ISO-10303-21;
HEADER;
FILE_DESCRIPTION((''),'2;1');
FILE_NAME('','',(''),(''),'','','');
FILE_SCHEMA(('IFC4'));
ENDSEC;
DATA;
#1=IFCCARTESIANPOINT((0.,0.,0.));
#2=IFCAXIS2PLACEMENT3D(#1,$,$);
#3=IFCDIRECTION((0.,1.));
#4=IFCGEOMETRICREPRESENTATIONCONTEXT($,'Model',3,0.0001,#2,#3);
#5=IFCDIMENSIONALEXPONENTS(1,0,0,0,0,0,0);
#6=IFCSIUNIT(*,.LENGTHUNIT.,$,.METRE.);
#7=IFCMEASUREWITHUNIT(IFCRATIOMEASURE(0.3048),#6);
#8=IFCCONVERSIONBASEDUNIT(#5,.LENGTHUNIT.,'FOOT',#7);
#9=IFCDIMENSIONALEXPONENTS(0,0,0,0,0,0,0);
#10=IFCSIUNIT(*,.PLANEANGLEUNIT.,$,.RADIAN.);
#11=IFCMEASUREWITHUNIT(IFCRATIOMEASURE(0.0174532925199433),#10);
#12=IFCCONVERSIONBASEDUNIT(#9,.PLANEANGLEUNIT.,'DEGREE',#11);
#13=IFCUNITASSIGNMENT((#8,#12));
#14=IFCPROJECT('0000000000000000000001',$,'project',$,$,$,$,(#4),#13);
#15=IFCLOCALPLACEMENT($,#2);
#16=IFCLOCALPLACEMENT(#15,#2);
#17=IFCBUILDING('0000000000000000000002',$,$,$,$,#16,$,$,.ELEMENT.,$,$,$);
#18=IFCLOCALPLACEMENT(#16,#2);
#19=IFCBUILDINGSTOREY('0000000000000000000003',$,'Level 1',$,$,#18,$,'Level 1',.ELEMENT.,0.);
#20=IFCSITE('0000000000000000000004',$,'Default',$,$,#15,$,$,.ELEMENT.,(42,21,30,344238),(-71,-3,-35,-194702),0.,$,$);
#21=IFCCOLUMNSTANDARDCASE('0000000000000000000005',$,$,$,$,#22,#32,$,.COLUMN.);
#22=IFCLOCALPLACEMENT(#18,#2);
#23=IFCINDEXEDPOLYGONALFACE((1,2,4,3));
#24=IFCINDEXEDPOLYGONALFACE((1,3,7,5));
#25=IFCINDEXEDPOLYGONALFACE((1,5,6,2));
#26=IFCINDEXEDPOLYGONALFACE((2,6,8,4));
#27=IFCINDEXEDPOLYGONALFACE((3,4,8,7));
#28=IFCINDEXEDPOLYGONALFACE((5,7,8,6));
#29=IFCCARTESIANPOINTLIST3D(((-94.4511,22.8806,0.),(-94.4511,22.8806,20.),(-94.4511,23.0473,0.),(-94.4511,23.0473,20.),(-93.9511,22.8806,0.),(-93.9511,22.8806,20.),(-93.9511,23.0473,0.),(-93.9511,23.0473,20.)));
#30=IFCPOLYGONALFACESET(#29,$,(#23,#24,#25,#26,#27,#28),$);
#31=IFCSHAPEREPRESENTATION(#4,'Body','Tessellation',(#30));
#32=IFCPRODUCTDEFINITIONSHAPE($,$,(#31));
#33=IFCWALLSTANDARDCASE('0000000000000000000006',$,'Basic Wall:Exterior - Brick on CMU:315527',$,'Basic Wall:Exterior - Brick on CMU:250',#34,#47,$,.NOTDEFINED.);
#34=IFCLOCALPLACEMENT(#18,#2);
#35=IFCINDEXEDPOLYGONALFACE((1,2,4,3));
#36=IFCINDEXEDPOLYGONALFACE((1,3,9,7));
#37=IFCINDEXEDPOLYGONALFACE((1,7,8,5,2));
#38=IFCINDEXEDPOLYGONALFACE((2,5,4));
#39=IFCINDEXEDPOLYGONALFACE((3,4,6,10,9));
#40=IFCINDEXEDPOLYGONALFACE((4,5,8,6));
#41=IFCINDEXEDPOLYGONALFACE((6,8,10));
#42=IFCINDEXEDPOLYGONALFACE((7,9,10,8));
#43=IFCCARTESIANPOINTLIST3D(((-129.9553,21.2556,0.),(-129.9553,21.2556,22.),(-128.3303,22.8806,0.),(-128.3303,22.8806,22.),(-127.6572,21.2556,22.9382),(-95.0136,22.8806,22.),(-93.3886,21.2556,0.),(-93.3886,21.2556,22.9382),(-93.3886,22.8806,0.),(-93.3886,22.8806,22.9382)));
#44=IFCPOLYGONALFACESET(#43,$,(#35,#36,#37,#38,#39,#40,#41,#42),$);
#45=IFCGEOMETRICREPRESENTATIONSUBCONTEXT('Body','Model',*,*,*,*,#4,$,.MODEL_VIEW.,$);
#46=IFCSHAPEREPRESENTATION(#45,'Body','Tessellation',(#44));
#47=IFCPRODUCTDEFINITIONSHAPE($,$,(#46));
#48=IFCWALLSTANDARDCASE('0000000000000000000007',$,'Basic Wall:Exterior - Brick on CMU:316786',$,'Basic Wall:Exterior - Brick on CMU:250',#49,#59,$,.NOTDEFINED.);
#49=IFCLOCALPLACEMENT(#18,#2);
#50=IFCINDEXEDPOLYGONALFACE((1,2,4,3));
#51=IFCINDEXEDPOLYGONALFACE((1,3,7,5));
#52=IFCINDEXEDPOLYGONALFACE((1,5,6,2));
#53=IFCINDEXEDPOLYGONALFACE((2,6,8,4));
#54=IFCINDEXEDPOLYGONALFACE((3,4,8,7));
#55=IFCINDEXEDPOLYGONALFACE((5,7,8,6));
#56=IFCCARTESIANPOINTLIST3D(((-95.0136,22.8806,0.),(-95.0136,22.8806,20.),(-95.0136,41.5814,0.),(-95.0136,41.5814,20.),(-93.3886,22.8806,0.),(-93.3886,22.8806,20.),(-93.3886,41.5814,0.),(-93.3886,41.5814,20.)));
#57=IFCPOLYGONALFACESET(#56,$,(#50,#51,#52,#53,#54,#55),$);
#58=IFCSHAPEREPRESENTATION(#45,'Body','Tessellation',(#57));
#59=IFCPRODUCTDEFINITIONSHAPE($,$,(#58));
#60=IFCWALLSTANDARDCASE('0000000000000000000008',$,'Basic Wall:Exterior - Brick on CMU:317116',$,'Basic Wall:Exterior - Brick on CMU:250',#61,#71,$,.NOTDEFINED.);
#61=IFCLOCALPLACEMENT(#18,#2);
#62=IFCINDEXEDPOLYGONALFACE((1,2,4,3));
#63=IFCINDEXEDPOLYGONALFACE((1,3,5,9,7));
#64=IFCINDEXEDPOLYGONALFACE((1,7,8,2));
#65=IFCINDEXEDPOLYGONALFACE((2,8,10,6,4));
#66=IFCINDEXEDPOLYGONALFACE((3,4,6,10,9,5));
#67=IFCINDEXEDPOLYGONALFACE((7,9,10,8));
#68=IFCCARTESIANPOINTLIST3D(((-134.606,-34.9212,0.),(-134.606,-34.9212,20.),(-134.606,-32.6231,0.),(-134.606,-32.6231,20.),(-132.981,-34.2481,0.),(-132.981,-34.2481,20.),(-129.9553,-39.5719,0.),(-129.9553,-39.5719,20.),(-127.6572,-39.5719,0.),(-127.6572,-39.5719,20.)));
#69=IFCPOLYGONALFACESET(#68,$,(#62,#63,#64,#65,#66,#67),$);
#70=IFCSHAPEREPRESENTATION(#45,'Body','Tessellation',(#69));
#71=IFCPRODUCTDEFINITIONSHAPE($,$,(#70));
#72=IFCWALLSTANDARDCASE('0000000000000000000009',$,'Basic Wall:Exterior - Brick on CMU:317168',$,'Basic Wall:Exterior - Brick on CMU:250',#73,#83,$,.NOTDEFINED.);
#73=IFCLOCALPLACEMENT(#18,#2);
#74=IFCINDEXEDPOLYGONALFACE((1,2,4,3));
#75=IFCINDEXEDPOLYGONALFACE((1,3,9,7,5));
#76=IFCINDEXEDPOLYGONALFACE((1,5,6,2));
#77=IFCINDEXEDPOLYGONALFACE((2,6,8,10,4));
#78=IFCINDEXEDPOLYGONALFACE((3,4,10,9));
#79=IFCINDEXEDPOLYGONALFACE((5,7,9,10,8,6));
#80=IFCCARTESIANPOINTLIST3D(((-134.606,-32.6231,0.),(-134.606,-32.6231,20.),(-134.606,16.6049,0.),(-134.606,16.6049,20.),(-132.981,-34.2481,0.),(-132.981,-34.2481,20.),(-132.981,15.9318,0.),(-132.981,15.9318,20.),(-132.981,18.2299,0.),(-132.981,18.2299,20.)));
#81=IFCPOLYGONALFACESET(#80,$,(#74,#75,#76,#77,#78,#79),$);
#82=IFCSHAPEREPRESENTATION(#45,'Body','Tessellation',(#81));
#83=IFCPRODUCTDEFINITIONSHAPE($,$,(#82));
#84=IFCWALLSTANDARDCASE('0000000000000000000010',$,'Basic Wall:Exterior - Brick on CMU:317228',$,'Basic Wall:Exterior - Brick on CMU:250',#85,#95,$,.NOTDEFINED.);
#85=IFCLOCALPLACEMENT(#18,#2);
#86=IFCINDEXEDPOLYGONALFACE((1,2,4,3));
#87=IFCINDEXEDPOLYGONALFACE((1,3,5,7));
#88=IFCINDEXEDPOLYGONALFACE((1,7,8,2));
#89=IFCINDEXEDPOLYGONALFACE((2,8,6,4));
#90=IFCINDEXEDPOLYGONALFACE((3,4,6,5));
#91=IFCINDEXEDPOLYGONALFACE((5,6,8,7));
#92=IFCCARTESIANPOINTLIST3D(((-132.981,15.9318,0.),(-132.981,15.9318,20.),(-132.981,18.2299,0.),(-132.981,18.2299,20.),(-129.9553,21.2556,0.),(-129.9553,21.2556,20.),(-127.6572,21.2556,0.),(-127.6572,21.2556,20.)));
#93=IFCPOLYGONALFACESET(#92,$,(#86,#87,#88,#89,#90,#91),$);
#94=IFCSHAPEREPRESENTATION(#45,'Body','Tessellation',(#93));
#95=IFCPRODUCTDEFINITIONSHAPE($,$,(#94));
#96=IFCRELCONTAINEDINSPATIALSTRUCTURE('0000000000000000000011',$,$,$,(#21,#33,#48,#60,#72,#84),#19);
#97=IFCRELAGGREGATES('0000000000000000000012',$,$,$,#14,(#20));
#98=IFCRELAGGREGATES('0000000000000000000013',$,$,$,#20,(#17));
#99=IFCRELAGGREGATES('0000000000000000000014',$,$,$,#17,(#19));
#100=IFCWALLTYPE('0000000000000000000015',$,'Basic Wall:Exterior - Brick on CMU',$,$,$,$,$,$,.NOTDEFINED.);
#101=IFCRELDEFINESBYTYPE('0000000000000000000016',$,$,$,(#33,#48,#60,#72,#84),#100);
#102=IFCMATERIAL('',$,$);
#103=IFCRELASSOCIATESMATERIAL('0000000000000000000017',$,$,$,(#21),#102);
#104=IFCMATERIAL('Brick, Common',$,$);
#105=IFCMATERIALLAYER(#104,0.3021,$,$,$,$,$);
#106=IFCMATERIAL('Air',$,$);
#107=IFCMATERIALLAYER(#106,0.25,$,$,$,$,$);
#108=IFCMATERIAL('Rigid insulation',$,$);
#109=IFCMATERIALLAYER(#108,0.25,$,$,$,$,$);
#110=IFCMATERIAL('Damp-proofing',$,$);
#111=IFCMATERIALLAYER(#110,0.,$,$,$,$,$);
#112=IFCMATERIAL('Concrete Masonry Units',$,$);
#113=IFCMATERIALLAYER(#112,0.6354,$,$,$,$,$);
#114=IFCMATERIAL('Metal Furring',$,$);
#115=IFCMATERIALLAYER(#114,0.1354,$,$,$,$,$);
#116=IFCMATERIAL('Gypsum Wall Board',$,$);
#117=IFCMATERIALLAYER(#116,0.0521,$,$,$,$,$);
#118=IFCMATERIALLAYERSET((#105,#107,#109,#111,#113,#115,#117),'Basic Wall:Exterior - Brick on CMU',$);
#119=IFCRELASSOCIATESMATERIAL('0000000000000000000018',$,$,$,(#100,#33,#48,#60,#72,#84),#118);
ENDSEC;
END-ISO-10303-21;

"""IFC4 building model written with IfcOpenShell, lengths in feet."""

from ifc_helpers import new_model, entity, si_unit, converted_unit, direction, frame, frame_2d, origin, place, context, subcontext, project, spatial, polyline, rectangle, outline, extrude, clip, bounded_halfspace, material, layer, layer_set, layer_usage, type_object, element, save


model = new_model("IFC4")

# Units and contexts
model_context = context("Model", 3, precision=0.0001, world=origin(), true_north=direction((0.0, 1.0)))
body_context = subcontext(model_context, "Body", "Model", "MODEL_VIEW")
ifc_project = project(units=[converted_unit("LENGTHUNIT", "FOOT", entity("IfcRatioMeasure", 0.3048), si_unit("LENGTHUNIT", "METRE"), dimensions=[1, 0, 0, 0, 0, 0, 0]), converted_unit("PLANEANGLEUNIT", "DEGREE", entity("IfcRatioMeasure", 0.0174532925199433), si_unit("PLANEANGLEUNIT", "RADIAN"), dimensions=[0, 0, 0, 0, 0, 0, 0])], contexts=[model_context])

# Site, building, storey
site_placement = place(None, origin())
site = spatial("IfcSite", under=ifc_project, at=site_placement, Name="Default", CompositionType="ELEMENT", RefLatitude=(42, 21, 30, 344238), RefLongitude=(-71, -3, -35, -194702), RefElevation=0.0)
building_placement = place(site_placement, origin())
building = spatial("IfcBuilding", under=site, at=building_placement, CompositionType="ELEMENT")
storey_placement = place(building_placement, origin())
storey = spatial("IfcBuildingStorey", under=building, at=storey_placement, Name="Level 1", LongName="Level 1", CompositionType="ELEMENT", Elevation=0.0)

# Column
ifc_material_1 = material(Name="")
wall_1_placement = place(storey_placement, frame((-94.2011, 22.8806, 0.0), z_axis=(0.0, 0.0, 1.0), x_axis=(0.0, 1.0, 0.0)))
for number, where, z_axis, x_axis in (
    (1, (0.0833, 0.0, 0.0), (0.0, 0.0, 1.0), (1.0, 0.0, 0.0)),
):
    element("IfcColumnStandardCase", number, at=place(wall_1_placement, frame(where, z_axis=z_axis, x_axis=x_axis)), inside=storey, material=ifc_material_1, PredefinedType="COLUMN", context=model_context, shape_type="SweptSolid", body=[
        extrude(rectangle(XDim=0.1667, YDim=0.5), origin(), (0.0, 0.0, 1.0), 20.0),
    ])

# Walls
ifc_material_2 = material(Name="Brick, Common")
ifc_layer_1 = layer(ifc_material_2, 0.3021)
ifc_material_3 = material(Name="Air")
ifc_layer_2 = layer(ifc_material_3, 0.25)
ifc_material_4 = material(Name="Rigid insulation")
ifc_layer_3 = layer(ifc_material_4, 0.25)
ifc_material_5 = material(Name="Damp-proofing")
ifc_layer_4 = layer(ifc_material_5, 0.0)
ifc_material_6 = material(Name="Concrete Masonry Units")
ifc_layer_5 = layer(ifc_material_6, 0.6354)
ifc_material_7 = material(Name="Metal Furring")
ifc_layer_6 = layer(ifc_material_7, 0.1354)
ifc_material_8 = material(Name="Gypsum Wall Board")
ifc_layer_7 = layer(ifc_material_8, 0.0521)
ifc_layer_set = layer_set([ifc_layer_1, ifc_layer_2, ifc_layer_3, ifc_layer_4, ifc_layer_5, ifc_layer_6, ifc_layer_7], Name="Basic Wall:Exterior - Brick on CMU")
ifc_layer_usage_1 = layer_usage(ifc_layer_set, "AXIS2", "NEGATIVE", 0.8125)
wall_type = type_object("IfcWallType", Name="Basic Wall:Exterior - Brick on CMU", PredefinedType="NOTDEFINED", material=ifc_layer_set)
wall_2_placement = place(storey_placement, frame((-129.9553, 22.0681, 0.0)))
element("IfcWallStandardCase", 2, at=wall_2_placement, inside=storey, type_object=wall_type, material=ifc_layer_usage_1, Name="Basic Wall:Exterior - Brick on CMU:315527", ObjectType="Basic Wall:Exterior - Brick on CMU:250", PredefinedType="NOTDEFINED", context=body_context, shape_type="Clipping", body=[
    clip(clip(clip(extrude(outline(polyline([(36.5667, -0.8125), (36.5667, 0.8125), (34.9417, 0.8125), (1.625, 0.8125), (0.0, -0.8125), (2.2981, -0.8125), (36.5667, -0.8125)])), origin(), (0.0, 0.0, 1.0), 22.9382), bounded_halfspace(frame((2.2981, -0.8125, 22.9382), z_axis=(0.0, 0.5, 0.866025), x_axis=(-1.0, 0.0, 0.0)), False, frame((2.2981, -0.8125, 22.9382)), polyline([(0.0, 0.0), (34.2686, 0.0), (32.6436, 1.625), (-0.6731, 1.625), (0.0, 0.0)]))), bounded_halfspace(frame((0.0, -0.8125, 22.0), z_axis=(-0.353553, 0.353553, 0.866025), x_axis=(-0.707107, -0.707107, 0.0)), False, frame((0.0, -0.8125, 22.0)), polyline([(0.0, 0.0), (2.2981, 0.0), (1.625, 1.625), (0.0, 0.0)]))), bounded_halfspace(frame((36.5667, -0.8125, 22.9382), z_axis=(-0.5, 0.0, 0.866025), x_axis=(0.0, -1.0, 0.0)), False, frame((36.5667, -0.8125, 22.9382)), polyline([(0.0, 0.0), (0.0, 1.625), (-1.625, 1.625), (0.0, 0.0)]))),
])
ifc_layer_usage_2 = layer_usage(ifc_layer_set, "AXIS2", "NEGATIVE", 0.8125)
element("IfcWallStandardCase", 3, at=wall_1_placement, inside=storey, type_object=wall_type, material=ifc_layer_usage_2, Name="Basic Wall:Exterior - Brick on CMU:316786", ObjectType="Basic Wall:Exterior - Brick on CMU:250", PredefinedType="NOTDEFINED", context=body_context, shape_type="SweptSolid", body=[
    extrude(rectangle(XDim=18.7008, YDim=1.625, at=frame_2d((9.3504, 0.0), x_axis=(-1.0, 0.0))), origin(), (0.0, 0.0, 1.0), 20.0),
])
ifc_layer_usage_3 = layer_usage(ifc_layer_set, "AXIS2", "NEGATIVE", 0.8125)
wall_3_placement = place(storey_placement, frame((-128.2317, -40.1464, 0.0), z_axis=(0.0, 0.0, 1.0), x_axis=(-0.707107, 0.707107, 0.0)))
element("IfcWallStandardCase", 4, at=wall_3_placement, inside=storey, type_object=wall_type, material=ifc_layer_usage_3, Name="Basic Wall:Exterior - Brick on CMU:317116", ObjectType="Basic Wall:Exterior - Brick on CMU:250", PredefinedType="NOTDEFINED", context=body_context, shape_type="SweptSolid", body=[
    extrude(outline(polyline([(9.8271, -0.8125), (8.2021, 0.8125), (1.625, 0.8125), (0.0, -0.8125), (7.529, -0.8125), (9.8271, -0.8125)])), origin(), (0.0, 0.0, 1.0), 20.0),
])
ifc_layer_usage_4 = layer_usage(ifc_layer_set, "AXIS2", "NEGATIVE", 0.8125)
wall_4_placement = place(storey_placement, frame((-133.7935, -34.2481, 0.0), z_axis=(0.0, 0.0, 1.0), x_axis=(0.0, 1.0, 0.0)))
element("IfcWallStandardCase", 5, at=wall_4_placement, inside=storey, type_object=wall_type, material=ifc_layer_usage_4, Name="Basic Wall:Exterior - Brick on CMU:317168", ObjectType="Basic Wall:Exterior - Brick on CMU:250", PredefinedType="NOTDEFINED", context=body_context, shape_type="SweptSolid", body=[
    extrude(outline(polyline([(52.478, -0.8125), (50.853, 0.8125), (1.625, 0.8125), (0.0, -0.8125), (50.1799, -0.8125), (52.478, -0.8125)])), origin(), (0.0, 0.0, 1.0), 20.0),
])
ifc_layer_usage_5 = layer_usage(ifc_layer_set, "AXIS2", "NEGATIVE", 0.8125)
wall_5_placement = place(storey_placement, frame((-133.5555, 16.5063, 0.0), z_axis=(0.0, 0.0, 1.0), x_axis=(0.707107, 0.707107, 0.0)))
element("IfcWallStandardCase", 6, at=wall_5_placement, inside=storey, type_object=wall_type, material=ifc_layer_usage_5, Name="Basic Wall:Exterior - Brick on CMU:317228", ObjectType="Basic Wall:Exterior - Brick on CMU:250", PredefinedType="NOTDEFINED", context=body_context, shape_type="SweptSolid", body=[
    extrude(outline(polyline([(7.529, -0.8125), (5.904, 0.8125), (1.625, 0.8125), (0.0, -0.8125), (7.529, -0.8125)])), origin(), (0.0, 0.0, 1.0), 20.0),
])

save(model, "model.ifc")
